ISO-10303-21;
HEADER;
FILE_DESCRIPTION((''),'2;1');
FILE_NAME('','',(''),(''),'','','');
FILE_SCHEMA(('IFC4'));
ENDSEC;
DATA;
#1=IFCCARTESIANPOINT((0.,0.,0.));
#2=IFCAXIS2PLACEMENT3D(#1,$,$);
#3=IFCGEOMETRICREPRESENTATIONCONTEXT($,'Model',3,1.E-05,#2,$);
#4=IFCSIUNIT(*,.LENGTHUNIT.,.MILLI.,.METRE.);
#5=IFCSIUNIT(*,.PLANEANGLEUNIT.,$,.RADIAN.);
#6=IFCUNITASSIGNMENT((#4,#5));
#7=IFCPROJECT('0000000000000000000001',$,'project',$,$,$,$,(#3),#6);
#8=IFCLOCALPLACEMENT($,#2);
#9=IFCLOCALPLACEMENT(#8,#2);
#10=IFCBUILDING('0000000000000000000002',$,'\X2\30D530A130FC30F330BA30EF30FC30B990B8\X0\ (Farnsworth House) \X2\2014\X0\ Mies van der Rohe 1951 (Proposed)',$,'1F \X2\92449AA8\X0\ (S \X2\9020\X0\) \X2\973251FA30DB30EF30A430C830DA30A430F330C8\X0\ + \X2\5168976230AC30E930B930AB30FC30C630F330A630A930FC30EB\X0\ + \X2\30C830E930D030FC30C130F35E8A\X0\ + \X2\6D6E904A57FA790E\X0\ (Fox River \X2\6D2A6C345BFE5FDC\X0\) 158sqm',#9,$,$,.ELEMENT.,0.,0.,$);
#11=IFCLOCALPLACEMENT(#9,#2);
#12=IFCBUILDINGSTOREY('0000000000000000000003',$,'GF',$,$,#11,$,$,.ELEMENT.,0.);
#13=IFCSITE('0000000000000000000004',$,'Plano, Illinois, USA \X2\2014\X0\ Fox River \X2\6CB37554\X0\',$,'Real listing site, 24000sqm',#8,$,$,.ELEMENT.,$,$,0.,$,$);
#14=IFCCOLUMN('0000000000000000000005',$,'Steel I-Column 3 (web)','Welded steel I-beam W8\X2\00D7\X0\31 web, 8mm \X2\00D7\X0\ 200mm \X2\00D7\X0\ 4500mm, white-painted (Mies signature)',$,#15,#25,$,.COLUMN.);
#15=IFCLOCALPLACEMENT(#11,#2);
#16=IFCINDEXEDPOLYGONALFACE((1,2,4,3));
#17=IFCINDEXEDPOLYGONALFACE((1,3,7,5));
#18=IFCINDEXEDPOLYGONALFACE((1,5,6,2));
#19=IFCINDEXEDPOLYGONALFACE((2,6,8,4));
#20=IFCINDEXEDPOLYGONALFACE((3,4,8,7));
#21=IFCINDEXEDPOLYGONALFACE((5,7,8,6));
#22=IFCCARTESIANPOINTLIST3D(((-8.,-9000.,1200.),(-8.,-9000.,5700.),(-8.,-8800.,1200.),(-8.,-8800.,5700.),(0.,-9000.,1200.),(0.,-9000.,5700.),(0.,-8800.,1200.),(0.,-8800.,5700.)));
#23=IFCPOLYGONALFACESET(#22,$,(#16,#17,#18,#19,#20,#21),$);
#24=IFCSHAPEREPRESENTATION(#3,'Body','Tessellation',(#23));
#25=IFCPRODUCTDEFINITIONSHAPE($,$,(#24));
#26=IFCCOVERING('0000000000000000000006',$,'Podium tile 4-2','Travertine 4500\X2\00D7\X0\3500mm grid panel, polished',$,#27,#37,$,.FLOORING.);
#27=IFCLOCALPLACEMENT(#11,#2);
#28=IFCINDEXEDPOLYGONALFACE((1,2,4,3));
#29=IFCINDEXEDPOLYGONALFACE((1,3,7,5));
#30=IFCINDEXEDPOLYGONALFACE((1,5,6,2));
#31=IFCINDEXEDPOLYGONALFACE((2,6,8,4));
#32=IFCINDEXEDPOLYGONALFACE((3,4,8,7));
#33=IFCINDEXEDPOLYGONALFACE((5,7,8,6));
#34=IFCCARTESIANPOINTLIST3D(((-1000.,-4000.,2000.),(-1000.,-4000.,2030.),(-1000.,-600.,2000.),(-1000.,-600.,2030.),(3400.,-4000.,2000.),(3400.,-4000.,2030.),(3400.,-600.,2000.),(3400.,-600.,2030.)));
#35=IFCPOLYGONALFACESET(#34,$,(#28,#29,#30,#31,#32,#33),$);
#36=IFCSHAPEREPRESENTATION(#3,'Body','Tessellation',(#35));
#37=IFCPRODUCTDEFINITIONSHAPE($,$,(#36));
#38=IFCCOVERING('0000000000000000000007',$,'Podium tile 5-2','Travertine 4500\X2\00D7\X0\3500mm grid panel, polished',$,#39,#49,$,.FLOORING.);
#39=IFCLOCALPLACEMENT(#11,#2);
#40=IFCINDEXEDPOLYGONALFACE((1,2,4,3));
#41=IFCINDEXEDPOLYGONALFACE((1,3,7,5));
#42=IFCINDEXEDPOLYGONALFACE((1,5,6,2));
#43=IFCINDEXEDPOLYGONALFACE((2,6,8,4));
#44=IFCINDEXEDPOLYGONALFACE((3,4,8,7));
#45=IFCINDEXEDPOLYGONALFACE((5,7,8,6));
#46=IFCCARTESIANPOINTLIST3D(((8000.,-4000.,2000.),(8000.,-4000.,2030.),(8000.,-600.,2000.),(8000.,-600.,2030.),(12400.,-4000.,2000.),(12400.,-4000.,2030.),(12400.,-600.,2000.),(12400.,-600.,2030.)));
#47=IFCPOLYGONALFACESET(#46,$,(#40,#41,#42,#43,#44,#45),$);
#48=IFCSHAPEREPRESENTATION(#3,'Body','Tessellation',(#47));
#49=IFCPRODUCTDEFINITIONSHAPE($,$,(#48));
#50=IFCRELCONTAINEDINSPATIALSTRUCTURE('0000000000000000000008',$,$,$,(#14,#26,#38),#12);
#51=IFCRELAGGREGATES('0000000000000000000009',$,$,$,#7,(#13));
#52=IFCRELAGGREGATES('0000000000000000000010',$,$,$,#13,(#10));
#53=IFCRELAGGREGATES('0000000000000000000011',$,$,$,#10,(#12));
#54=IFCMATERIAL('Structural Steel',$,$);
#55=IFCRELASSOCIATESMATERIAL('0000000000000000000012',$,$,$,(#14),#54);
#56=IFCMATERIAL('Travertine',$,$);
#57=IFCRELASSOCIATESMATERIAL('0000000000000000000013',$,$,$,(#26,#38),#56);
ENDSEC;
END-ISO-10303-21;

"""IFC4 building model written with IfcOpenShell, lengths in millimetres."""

from ifc_helpers import new_model, si_unit, frame, frame_2d, origin, place, context, project, spatial, rectangle, extrude, material, element, save


model = new_model("IFC4")

# Units and contexts
model_context = context("Model", 3, precision=1e-05, world=origin())
ifc_project = project(units=[si_unit("LENGTHUNIT", "METRE", prefix="MILLI"), si_unit("PLANEANGLEUNIT", "RADIAN")], contexts=[model_context])

# Site, building, storey
site_placement = place(None, origin())
site = spatial("IfcSite", under=ifc_project, at=site_placement, Name="Plano, Illinois, USA — Fox River 河畔", ObjectType="Real listing site, 24000sqm", CompositionType="ELEMENT", RefElevation=0.0)
building_placement = place(site_placement, origin())
building = spatial("IfcBuilding", under=site, at=building_placement, Name="ファーンズワース邸 (Farnsworth House) — Mies van der Rohe 1951 (Proposed)", ObjectType="1F 鉄骨 (S 造) 露出ホワイトペイント + 全面ガラスカーテンウォール + トラバーチン床 + 浮遊基礎 (Fox River 洪水対応) 158sqm", CompositionType="ELEMENT", ElevationOfRefHeight=0.0, ElevationOfTerrain=0.0)
storey_placement = place(building_placement, origin())
storey = spatial("IfcBuildingStorey", under=building, at=storey_placement, Name="GF", CompositionType="ELEMENT", Elevation=0.0)

# Column
ifc_material_1 = material(Name="Structural Steel")
column_1_placement = place(storey_placement, frame((-4.0, -4500.0, 600.0)))
element("IfcColumn", 1, at=column_1_placement, inside=storey, material=ifc_material_1, Name="Steel I-Column 3 (web)", Description="Welded steel I-beam W8×31 web, 8mm × 200mm × 4500mm, white-painted (Mies signature)", PredefinedType="COLUMN", context=model_context, shape_type="SweptSolid", body=[
    extrude(rectangle(XDim=8.0, YDim=200.0, at=frame_2d((4.0, 100.0))), frame((-4.0, -4500.0, 600.0)), (0.0, 0.0, 1.0), 4500.0),
])

# Coverings
ifc_material_2 = material(Name="Travertine")
covering_1_placement = place(storey_placement, frame((-500.0, -2000.0, 1000.0)))
element("IfcCovering", 2, at=covering_1_placement, inside=storey, material=ifc_material_2, Name="Podium tile 4-2", Description="Travertine 4500×3500mm grid panel, polished", PredefinedType="FLOORING", context=model_context, shape_type="SweptSolid", body=[
    extrude(rectangle(XDim=4400.0, YDim=3400.0, at=frame_2d((2200.0, 1700.0))), frame((-500.0, -2000.0, 1000.0)), (0.0, 0.0, 1.0), 30.0),
])
covering_2_placement = place(storey_placement, frame((4000.0, -2000.0, 1000.0)))
element("IfcCovering", 3, at=covering_2_placement, inside=storey, material=ifc_material_2, Name="Podium tile 5-2", Description="Travertine 4500×3500mm grid panel, polished", PredefinedType="FLOORING", context=model_context, shape_type="SweptSolid", body=[
    extrude(rectangle(XDim=4400.0, YDim=3400.0, at=frame_2d((2200.0, 1700.0))), frame((4000.0, -2000.0, 1000.0)), (0.0, 0.0, 1.0), 30.0),
])

save(model, "model.ifc")
